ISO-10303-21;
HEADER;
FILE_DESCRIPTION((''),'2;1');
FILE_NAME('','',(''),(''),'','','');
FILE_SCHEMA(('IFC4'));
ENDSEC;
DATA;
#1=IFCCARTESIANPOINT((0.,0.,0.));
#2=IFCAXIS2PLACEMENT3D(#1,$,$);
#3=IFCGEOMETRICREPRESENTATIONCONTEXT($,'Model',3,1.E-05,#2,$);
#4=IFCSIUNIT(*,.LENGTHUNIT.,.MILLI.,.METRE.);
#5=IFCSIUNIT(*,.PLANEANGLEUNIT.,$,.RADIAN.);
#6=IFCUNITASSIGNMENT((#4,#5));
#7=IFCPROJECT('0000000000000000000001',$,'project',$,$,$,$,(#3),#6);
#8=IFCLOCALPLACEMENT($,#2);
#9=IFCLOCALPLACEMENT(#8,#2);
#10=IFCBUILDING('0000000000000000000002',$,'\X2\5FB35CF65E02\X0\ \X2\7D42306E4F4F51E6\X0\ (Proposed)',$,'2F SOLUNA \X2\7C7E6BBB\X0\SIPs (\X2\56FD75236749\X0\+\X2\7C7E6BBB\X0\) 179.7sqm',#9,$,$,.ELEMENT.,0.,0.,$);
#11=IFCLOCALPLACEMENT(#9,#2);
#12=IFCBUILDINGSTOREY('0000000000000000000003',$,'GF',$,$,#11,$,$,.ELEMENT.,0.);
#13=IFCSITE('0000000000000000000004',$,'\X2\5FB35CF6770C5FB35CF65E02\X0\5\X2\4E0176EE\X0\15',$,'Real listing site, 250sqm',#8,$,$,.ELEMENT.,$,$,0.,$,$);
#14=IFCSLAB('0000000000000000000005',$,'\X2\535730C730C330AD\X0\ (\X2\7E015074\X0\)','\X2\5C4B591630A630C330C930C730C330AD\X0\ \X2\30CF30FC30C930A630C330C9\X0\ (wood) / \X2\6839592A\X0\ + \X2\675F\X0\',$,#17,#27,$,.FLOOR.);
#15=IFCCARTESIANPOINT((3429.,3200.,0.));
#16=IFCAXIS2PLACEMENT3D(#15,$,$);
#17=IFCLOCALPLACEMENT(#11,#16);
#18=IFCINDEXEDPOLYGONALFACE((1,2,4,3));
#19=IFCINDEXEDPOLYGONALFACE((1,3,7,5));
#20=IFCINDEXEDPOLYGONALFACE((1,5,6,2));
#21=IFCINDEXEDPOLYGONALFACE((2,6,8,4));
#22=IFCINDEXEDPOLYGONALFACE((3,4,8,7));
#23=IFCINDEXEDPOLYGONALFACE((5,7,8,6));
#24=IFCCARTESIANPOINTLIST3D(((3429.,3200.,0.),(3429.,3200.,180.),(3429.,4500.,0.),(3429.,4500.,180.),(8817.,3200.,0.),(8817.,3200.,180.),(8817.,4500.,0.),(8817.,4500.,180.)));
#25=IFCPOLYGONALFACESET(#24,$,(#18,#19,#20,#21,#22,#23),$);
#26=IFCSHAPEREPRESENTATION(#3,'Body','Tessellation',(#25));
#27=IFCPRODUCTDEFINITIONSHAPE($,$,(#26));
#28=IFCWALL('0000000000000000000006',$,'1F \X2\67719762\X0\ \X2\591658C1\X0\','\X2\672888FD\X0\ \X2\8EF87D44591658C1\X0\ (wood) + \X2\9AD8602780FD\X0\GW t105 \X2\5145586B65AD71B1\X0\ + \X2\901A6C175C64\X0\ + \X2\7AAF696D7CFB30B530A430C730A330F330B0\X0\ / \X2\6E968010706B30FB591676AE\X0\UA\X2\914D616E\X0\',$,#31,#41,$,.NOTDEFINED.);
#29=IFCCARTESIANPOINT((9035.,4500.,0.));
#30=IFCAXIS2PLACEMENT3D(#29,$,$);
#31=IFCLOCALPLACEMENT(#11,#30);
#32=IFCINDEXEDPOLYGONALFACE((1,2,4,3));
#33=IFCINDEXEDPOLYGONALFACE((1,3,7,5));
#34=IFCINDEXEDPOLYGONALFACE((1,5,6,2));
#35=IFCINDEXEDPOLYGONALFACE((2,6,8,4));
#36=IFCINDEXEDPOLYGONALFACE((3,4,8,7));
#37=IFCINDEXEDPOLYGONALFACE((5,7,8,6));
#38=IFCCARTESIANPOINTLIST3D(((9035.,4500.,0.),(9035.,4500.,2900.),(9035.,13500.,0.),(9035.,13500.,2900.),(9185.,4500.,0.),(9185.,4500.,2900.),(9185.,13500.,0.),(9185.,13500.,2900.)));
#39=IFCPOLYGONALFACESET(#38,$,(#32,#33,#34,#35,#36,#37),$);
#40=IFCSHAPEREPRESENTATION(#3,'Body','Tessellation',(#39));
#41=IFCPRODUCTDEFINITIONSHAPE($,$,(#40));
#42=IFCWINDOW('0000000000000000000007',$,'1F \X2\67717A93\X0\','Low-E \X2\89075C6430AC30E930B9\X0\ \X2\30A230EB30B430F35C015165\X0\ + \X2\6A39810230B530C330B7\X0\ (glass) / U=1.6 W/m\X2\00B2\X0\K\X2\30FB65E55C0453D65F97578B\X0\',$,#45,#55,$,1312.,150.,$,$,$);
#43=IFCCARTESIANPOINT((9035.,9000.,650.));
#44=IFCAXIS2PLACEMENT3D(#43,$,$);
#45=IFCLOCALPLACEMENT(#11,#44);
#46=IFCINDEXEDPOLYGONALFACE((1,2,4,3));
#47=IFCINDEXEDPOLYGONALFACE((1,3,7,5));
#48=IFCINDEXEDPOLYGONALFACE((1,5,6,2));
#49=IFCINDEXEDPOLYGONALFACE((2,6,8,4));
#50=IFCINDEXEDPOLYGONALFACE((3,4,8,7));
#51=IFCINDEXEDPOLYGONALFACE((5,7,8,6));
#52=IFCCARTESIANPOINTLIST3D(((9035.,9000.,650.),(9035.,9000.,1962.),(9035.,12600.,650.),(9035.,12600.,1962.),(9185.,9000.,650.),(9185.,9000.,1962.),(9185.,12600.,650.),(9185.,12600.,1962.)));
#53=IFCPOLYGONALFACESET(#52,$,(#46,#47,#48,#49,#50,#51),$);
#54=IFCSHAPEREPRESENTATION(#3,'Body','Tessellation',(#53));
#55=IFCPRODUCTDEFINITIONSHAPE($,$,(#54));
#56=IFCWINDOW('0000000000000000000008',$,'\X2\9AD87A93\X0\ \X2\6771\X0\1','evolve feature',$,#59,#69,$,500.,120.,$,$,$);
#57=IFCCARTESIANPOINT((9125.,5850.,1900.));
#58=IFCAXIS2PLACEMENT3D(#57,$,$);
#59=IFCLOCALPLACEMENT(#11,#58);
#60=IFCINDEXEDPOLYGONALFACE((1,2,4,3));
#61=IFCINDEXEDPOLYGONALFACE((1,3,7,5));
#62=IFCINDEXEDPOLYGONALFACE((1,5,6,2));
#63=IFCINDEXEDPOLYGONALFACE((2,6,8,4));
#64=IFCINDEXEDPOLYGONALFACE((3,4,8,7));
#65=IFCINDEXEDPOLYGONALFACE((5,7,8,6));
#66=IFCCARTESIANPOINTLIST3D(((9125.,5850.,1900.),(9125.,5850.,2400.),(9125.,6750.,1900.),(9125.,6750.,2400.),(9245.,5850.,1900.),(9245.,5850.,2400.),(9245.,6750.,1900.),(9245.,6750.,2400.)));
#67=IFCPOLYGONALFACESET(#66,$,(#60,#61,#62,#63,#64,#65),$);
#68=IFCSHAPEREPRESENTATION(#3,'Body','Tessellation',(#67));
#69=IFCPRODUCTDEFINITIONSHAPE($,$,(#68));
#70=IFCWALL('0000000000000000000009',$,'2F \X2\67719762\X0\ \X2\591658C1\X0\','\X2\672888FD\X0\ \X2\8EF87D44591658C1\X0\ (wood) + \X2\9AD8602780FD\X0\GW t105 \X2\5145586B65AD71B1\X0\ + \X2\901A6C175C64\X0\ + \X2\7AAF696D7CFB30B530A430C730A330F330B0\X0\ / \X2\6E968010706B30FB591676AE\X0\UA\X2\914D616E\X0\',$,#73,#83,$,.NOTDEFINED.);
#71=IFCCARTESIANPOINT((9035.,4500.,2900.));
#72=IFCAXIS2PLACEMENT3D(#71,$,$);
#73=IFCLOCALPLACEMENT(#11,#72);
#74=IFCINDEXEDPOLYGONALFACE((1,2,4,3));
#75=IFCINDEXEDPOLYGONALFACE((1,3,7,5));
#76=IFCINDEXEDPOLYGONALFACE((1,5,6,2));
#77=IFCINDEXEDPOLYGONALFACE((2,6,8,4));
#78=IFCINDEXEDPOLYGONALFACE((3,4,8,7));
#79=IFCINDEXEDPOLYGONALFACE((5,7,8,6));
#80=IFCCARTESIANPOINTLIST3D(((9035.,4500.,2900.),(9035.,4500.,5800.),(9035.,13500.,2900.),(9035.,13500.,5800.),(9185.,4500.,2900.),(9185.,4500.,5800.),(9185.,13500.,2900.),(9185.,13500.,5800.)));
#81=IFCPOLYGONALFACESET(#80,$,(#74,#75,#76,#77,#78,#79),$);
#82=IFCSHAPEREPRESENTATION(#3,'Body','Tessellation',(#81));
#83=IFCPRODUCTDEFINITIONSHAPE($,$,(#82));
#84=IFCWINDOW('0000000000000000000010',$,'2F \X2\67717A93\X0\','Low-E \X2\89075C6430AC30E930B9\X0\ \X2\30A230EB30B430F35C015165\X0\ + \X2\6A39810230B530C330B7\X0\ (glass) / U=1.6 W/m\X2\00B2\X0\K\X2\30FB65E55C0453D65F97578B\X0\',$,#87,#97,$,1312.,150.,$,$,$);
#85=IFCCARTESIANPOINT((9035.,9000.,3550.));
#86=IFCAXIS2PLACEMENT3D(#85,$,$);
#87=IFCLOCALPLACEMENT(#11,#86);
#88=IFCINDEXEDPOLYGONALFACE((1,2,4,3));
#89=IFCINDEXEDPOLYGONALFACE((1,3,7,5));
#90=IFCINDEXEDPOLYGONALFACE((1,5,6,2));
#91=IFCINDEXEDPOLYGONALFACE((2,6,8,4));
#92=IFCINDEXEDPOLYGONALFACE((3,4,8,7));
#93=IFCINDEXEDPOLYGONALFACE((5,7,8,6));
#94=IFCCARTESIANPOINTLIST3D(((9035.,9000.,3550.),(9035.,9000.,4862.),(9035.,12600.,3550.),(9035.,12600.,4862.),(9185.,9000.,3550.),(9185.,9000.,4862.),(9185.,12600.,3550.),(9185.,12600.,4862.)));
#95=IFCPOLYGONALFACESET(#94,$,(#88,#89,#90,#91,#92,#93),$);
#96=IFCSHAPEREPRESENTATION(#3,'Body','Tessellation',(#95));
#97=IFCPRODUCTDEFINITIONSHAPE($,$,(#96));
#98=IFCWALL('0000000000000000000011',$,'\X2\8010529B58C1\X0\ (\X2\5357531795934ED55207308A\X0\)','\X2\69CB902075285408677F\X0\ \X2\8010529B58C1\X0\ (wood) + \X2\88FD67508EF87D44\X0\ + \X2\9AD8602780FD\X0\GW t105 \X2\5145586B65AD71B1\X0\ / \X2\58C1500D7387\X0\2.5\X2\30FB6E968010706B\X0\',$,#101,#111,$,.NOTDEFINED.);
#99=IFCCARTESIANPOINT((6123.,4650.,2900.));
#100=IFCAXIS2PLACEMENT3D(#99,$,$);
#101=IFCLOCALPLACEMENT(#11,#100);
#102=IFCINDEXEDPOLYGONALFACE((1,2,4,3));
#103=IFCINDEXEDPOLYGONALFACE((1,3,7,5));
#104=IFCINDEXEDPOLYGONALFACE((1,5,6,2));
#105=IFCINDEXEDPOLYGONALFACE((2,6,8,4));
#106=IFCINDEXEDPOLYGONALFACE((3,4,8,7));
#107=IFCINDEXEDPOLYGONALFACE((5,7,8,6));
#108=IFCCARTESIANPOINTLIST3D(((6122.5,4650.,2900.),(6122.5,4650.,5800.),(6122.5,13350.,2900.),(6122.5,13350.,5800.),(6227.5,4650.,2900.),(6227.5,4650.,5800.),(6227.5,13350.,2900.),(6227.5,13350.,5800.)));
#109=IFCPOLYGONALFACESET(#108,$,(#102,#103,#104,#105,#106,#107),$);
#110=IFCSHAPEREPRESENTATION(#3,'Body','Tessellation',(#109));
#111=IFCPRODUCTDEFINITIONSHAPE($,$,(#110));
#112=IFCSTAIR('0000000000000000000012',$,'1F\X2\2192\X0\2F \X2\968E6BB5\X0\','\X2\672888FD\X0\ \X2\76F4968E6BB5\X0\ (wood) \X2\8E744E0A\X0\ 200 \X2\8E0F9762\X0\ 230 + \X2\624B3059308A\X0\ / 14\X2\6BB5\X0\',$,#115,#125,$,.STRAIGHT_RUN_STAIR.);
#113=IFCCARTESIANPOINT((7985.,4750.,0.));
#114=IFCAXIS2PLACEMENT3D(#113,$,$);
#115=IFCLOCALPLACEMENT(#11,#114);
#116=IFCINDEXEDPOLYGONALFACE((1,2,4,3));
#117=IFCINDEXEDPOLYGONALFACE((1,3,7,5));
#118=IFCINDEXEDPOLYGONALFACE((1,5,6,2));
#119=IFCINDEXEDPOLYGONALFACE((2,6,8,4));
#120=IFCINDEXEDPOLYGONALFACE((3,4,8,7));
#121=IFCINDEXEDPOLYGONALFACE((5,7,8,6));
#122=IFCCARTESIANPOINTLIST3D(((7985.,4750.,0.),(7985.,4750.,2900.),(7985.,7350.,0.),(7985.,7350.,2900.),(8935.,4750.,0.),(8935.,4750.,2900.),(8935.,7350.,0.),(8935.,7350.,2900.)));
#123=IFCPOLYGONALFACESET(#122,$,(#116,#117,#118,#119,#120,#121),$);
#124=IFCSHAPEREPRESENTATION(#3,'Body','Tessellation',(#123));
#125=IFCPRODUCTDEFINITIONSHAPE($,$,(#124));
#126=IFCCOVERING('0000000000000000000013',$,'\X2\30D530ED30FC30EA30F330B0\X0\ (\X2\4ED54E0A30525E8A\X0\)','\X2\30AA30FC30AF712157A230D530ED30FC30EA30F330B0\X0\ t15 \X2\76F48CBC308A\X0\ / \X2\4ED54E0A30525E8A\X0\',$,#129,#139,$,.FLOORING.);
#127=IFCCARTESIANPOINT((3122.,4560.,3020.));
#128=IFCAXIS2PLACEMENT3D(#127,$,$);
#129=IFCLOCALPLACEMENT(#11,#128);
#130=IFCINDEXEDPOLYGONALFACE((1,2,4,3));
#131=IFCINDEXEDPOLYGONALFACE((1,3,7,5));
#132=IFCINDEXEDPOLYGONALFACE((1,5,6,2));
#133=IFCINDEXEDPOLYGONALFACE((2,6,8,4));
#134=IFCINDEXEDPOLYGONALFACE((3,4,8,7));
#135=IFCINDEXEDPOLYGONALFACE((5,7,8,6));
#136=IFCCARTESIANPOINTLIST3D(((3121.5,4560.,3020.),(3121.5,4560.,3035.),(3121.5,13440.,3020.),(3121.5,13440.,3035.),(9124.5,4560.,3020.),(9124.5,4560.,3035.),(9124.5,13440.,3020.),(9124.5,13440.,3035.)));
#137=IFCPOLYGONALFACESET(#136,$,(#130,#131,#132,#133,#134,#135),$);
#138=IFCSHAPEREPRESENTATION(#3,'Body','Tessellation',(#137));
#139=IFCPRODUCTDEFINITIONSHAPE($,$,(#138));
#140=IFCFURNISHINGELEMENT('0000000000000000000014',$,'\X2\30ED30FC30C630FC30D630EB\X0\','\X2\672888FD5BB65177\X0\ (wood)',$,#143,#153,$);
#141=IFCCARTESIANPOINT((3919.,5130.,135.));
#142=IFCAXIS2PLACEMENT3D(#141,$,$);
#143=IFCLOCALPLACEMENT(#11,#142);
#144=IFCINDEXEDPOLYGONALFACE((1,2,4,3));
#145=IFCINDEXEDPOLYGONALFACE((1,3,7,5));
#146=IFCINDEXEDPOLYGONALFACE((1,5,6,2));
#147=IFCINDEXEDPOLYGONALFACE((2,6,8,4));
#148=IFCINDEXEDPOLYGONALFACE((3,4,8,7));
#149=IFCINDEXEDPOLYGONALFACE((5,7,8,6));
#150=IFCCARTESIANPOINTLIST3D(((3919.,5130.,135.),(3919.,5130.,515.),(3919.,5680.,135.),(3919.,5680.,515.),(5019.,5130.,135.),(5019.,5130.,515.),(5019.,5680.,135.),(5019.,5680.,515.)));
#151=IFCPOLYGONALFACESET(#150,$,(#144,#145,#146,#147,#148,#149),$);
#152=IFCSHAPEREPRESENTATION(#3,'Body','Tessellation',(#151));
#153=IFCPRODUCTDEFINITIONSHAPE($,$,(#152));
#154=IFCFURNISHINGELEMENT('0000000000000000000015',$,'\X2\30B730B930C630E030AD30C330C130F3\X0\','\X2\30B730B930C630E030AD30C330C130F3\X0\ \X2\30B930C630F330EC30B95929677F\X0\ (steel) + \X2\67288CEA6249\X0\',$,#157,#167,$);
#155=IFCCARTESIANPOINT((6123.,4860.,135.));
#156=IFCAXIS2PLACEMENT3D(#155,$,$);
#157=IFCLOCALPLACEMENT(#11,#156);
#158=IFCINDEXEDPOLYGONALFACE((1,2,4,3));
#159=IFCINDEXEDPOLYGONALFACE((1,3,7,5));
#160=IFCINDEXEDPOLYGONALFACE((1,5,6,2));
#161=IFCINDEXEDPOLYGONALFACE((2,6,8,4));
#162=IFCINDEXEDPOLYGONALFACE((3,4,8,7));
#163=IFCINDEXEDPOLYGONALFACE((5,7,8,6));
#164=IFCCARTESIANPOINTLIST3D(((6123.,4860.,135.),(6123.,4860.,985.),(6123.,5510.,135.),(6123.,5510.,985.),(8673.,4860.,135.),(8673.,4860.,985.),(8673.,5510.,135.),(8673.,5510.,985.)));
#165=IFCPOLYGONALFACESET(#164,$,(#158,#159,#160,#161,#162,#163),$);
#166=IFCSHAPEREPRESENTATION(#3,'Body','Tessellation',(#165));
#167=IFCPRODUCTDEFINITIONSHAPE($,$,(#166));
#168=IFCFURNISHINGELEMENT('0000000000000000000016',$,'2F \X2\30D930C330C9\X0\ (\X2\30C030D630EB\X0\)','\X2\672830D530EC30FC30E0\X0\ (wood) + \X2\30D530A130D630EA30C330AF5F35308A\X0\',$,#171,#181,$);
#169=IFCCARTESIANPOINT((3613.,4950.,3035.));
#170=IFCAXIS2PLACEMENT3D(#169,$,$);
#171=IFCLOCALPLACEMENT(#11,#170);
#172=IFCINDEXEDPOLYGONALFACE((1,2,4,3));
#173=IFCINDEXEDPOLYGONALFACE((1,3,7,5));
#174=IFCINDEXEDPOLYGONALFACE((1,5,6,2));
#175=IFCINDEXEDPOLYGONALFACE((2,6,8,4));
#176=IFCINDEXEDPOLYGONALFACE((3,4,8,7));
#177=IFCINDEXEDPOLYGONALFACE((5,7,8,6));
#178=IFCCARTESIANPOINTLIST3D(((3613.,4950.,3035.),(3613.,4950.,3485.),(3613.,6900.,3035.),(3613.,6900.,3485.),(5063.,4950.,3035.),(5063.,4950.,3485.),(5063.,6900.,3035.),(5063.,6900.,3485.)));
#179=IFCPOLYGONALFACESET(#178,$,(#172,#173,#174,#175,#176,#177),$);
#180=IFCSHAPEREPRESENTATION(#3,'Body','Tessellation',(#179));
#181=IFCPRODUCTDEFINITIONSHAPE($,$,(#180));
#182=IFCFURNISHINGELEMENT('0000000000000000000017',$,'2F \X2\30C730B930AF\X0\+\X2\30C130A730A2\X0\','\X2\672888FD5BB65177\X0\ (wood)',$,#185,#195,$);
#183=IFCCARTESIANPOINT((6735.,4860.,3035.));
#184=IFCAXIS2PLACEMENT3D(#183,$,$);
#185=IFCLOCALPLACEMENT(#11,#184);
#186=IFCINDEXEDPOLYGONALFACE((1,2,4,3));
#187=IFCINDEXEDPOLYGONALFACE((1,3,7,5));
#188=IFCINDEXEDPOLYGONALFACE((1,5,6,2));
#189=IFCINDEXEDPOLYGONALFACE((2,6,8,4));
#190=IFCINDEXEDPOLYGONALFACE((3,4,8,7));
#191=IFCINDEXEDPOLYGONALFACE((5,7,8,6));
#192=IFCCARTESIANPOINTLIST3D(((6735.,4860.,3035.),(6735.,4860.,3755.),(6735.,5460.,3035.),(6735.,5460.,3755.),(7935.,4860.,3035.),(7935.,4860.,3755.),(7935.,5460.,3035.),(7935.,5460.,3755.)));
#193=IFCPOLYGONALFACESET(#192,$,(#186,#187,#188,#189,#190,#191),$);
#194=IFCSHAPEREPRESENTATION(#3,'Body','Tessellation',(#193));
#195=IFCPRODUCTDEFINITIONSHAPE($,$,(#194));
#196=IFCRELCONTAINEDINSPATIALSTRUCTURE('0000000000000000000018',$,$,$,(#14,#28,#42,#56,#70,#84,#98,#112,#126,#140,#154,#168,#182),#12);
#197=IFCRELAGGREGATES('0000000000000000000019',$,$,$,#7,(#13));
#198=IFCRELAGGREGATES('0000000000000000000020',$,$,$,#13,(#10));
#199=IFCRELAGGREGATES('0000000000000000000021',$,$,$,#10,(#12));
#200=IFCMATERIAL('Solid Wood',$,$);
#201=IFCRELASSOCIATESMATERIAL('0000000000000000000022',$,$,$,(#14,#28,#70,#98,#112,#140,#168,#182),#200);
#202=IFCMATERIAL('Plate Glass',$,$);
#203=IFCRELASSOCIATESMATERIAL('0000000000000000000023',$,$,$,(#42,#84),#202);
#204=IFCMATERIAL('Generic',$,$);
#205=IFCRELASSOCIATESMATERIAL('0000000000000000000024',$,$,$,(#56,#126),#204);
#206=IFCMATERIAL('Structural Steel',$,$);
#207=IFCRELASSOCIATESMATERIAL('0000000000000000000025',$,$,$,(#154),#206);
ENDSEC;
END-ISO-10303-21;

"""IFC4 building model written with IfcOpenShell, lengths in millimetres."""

from ifc_helpers import new_model, si_unit, frame, frame_2d, origin, place, context, project, spatial, rectangle, extrude, material, element, fill, save


model = new_model("IFC4")

# Units and contexts
model_context = context("Model", 3, precision=1e-05, world=origin())
ifc_project = project(units=[si_unit("LENGTHUNIT", "METRE", prefix="MILLI"), si_unit("PLANEANGLEUNIT", "RADIAN")], contexts=[model_context])

# Site, building, storey
site_placement = place(None, origin())
site = spatial("IfcSite", under=ifc_project, at=site_placement, Name="徳島県徳島市5丁目15", ObjectType="Real listing site, 250sqm", CompositionType="ELEMENT", RefElevation=0.0)
building_placement = place(site_placement, origin())
building = spatial("IfcBuilding", under=site, at=building_placement, Name="徳島市 終の住処 (Proposed)", ObjectType="2F SOLUNA 籾殻SIPs (国産杉+籾殻) 179.7sqm", CompositionType="ELEMENT", ElevationOfRefHeight=0.0, ElevationOfTerrain=0.0)
storey_placement = place(building_placement, origin())
storey = spatial("IfcBuildingStorey", under=building, at=storey_placement, Name="GF", CompositionType="ELEMENT", Elevation=0.0)

# Slab
ifc_material_1 = material(Name="Solid Wood")
slab_placement = place(storey_placement, frame((3429.0, 3200.0, 0.0)))
element("IfcSlab", 1, at=slab_placement, inside=storey, material=ifc_material_1, Name="南デッキ (縁側)", Description="屋外ウッドデッキ ハードウッド (wood) / 根太 + 束", PredefinedType="FLOOR", context=model_context, shape_type="SweptSolid", body=[
    extrude(rectangle(XDim=5388.0, YDim=1300.0, at=frame_2d((2694.0, 650.0))), frame((3429.0, 3200.0, 0.0)), (0.0, 0.0, 1.0), 180.0),
])

# Wall, openings, windows
wall_1_placement = place(storey_placement, frame((9035.0, 4500.0, 0.0)))
wall_1 = element("IfcWall", 2, at=wall_1_placement, inside=storey, material=ifc_material_1, Name="1F 東面 外壁", Description="木製 軸組外壁 (wood) + 高性能GW t105 充填断熱 + 通気層 + 窯業系サイディング / 準耐火・外皮UA配慮", PredefinedType="NOTDEFINED", context=model_context, shape_type="SweptSolid", body=[
    extrude(rectangle(XDim=150.0, YDim=9000.0, at=frame_2d((75.0, 4500.0))), frame((9035.0, 4500.0, 0.0)), (0.0, 0.0, 1.0), 2900.0),
])
opening_1_placement = place(storey_placement, frame((9035.0, 9000.0, 650.0)))
opening_1 = element("IfcOpeningElement", 3, at=opening_1_placement, cuts=wall_1, PredefinedType="NOTDEFINED", context=model_context, shape_type="SweptSolid", body=[
    extrude(rectangle(XDim=150.0, YDim=3600.0, at=frame_2d((75.0, 1800.0))), frame((9035.0, 9000.0, 650.0)), (0.0, 0.0, 1.0), 1312.0),
])
opening_2_placement = place(storey_placement, frame((9125.0, 5850.0, 1900.0)))
opening_2 = element("IfcOpeningElement", 4, at=opening_2_placement, cuts=wall_1, PredefinedType="NOTDEFINED", context=model_context, shape_type="SweptSolid", body=[
    extrude(rectangle(XDim=120.0, YDim=900.0, at=frame_2d((60.0, 450.0))), frame((9125.0, 5850.0, 1900.0)), (0.0, 0.0, 1.0), 500.0),
])
ifc_material_2 = material(Name="Plate Glass")
window_1_placement = place(storey_placement, frame((9035.0, 9000.0, 650.0)))
window_1 = element("IfcWindow", 5, at=window_1_placement, inside=storey, material=ifc_material_2, Name="1F 東窓", Description="Low-E 複層ガラス アルゴン封入 + 樹脂サッシ (glass) / U=1.6 W/m²K・日射取得型", OverallHeight=1312.0, OverallWidth=150.0, context=model_context, shape_type="SweptSolid", body=[
    extrude(rectangle(XDim=150.0, YDim=3600.0, at=frame_2d((75.0, 1800.0))), frame((9035.0, 9000.0, 650.0)), (0.0, 0.0, 1.0), 1312.0),
])
fill(opening_1, window_1)
ifc_material_3 = material(Name="Generic")
window_2_placement = place(storey_placement, frame((9125.0, 5850.0, 1900.0)))
window_2 = element("IfcWindow", 6, at=window_2_placement, inside=storey, material=ifc_material_3, Name="高窓 東1", Description="evolve feature", OverallHeight=500.0, OverallWidth=120.0, context=model_context, shape_type="SweptSolid", body=[
    extrude(rectangle(XDim=120.0, YDim=900.0, at=frame_2d((60.0, 450.0))), frame((9125.0, 5850.0, 1900.0)), (0.0, 0.0, 1.0), 500.0),
])
fill(opening_2, window_2)

# Wall, opening, window
wall_2_placement = place(storey_placement, frame((9035.0, 4500.0, 2900.0)))
wall_2 = element("IfcWall", 7, at=wall_2_placement, inside=storey, material=ifc_material_1, Name="2F 東面 外壁", Description="木製 軸組外壁 (wood) + 高性能GW t105 充填断熱 + 通気層 + 窯業系サイディング / 準耐火・外皮UA配慮", PredefinedType="NOTDEFINED", context=model_context, shape_type="SweptSolid", body=[
    extrude(rectangle(XDim=150.0, YDim=9000.0, at=frame_2d((75.0, 4500.0))), frame((9035.0, 4500.0, 2900.0)), (0.0, 0.0, 1.0), 2900.0),
])
opening_3_placement = place(storey_placement, frame((9035.0, 9000.0, 3550.0)))
opening_3 = element("IfcOpeningElement", 8, at=opening_3_placement, cuts=wall_2, PredefinedType="NOTDEFINED", context=model_context, shape_type="SweptSolid", body=[
    extrude(rectangle(XDim=150.0, YDim=3600.0, at=frame_2d((75.0, 1800.0))), frame((9035.0, 9000.0, 3550.0)), (0.0, 0.0, 1.0), 1312.0),
])
window_3_placement = place(storey_placement, frame((9035.0, 9000.0, 3550.0)))
window_3 = element("IfcWindow", 9, at=window_3_placement, inside=storey, material=ifc_material_2, Name="2F 東窓", Description="Low-E 複層ガラス アルゴン封入 + 樹脂サッシ (glass) / U=1.6 W/m²K・日射取得型", OverallHeight=1312.0, OverallWidth=150.0, context=model_context, shape_type="SweptSolid", body=[
    extrude(rectangle(XDim=150.0, YDim=3600.0, at=frame_2d((75.0, 1800.0))), frame((9035.0, 9000.0, 3550.0)), (0.0, 0.0, 1.0), 1312.0),
])
fill(opening_3, window_3)

# Wall
wall_3_placement = place(storey_placement, frame((6123.0, 4650.0, 2900.0)))
element("IfcWall", 10, at=wall_3_placement, inside=storey, material=ifc_material_1, Name="耐力壁 (南北間仕切り)", Description="構造用合板 耐力壁 (wood) + 製材軸組 + 高性能GW t105 充填断熱 / 壁倍率2.5・準耐火", PredefinedType="NOTDEFINED", context=model_context, shape_type="SweptSolid", body=[
    extrude(rectangle(XDim=105.0, YDim=8700.0, at=frame_2d((52.0, 4350.0))), frame((6123.0, 4650.0, 2900.0)), (0.0, 0.0, 1.0), 2900.0),
])

# Stair
stair_placement = place(storey_placement, frame((7985.0, 4750.0, 0.0)))
element("IfcStair", 11, at=stair_placement, inside=storey, material=ifc_material_1, Name="1F→2F 階段", Description="木製 直階段 (wood) 蹴上 200 踏面 230 + 手すり / 14段", PredefinedType="STRAIGHT_RUN_STAIR", context=model_context, shape_type="SweptSolid", body=[
    extrude(rectangle(XDim=950.0, YDim=2600.0, at=frame_2d((475.0, 1300.0))), frame((7985.0, 4750.0, 0.0)), (0.0, 0.0, 1.0), 2900.0),
])

# Covering
covering_placement = place(storey_placement, frame((3122.0, 4560.0, 3020.0)))
element("IfcCovering", 12, at=covering_placement, inside=storey, material=ifc_material_3, Name="フローリング (仕上げ床)", Description="オーク無垢フローリング t15 直貼り / 仕上げ床", PredefinedType="FLOORING", context=model_context, shape_type="SweptSolid", body=[
    extrude(rectangle(XDim=6003.0, YDim=8880.0, at=frame_2d((3001.0, 4440.0))), frame((3122.0, 4560.0, 3020.0)), (0.0, 0.0, 1.0), 15.0),
])

# Furnishing elements
furnishing_1_placement = place(storey_placement, frame((3919.0, 5130.0, 135.0)))
element("IfcFurnishingElement", 13, at=furnishing_1_placement, inside=storey, material=ifc_material_1, Name="ローテーブル", Description="木製家具 (wood)", context=model_context, shape_type="SweptSolid", body=[
    extrude(rectangle(XDim=1100.0, YDim=550.0, at=frame_2d((550.0, 275.0))), frame((3919.0, 5130.0, 135.0)), (0.0, 0.0, 1.0), 380.0),
])
ifc_material_4 = material(Name="Structural Steel")
furnishing_2_placement = place(storey_placement, frame((6123.0, 4860.0, 135.0)))
element("IfcFurnishingElement", 14, at=furnishing_2_placement, inside=storey, material=ifc_material_4, Name="システムキッチン", Description="システムキッチン ステンレス天板 (steel) + 木質扉", context=model_context, shape_type="SweptSolid", body=[
    extrude(rectangle(XDim=2550.0, YDim=650.0, at=frame_2d((1275.0, 325.0))), frame((6123.0, 4860.0, 135.0)), (0.0, 0.0, 1.0), 850.0),
])
furnishing_3_placement = place(storey_placement, frame((3613.0, 4950.0, 3035.0)))
element("IfcFurnishingElement", 15, at=furnishing_3_placement, inside=storey, material=ifc_material_1, Name="2F ベッド (ダブル)", Description="木フレーム (wood) + ファブリック張り", context=model_context, shape_type="SweptSolid", body=[
    extrude(rectangle(XDim=1450.0, YDim=1950.0, at=frame_2d((725.0, 975.0))), frame((3613.0, 4950.0, 3035.0)), (0.0, 0.0, 1.0), 450.0),
])
furnishing_4_placement = place(storey_placement, frame((6735.0, 4860.0, 3035.0)))
element("IfcFurnishingElement", 16, at=furnishing_4_placement, inside=storey, material=ifc_material_1, Name="2F デスク+チェア", Description="木製家具 (wood)", context=model_context, shape_type="SweptSolid", body=[
    extrude(rectangle(XDim=1200.0, YDim=600.0, at=frame_2d((600.0, 300.0))), frame((6735.0, 4860.0, 3035.0)), (0.0, 0.0, 1.0), 720.0),
])

save(model, "model.ifc")
